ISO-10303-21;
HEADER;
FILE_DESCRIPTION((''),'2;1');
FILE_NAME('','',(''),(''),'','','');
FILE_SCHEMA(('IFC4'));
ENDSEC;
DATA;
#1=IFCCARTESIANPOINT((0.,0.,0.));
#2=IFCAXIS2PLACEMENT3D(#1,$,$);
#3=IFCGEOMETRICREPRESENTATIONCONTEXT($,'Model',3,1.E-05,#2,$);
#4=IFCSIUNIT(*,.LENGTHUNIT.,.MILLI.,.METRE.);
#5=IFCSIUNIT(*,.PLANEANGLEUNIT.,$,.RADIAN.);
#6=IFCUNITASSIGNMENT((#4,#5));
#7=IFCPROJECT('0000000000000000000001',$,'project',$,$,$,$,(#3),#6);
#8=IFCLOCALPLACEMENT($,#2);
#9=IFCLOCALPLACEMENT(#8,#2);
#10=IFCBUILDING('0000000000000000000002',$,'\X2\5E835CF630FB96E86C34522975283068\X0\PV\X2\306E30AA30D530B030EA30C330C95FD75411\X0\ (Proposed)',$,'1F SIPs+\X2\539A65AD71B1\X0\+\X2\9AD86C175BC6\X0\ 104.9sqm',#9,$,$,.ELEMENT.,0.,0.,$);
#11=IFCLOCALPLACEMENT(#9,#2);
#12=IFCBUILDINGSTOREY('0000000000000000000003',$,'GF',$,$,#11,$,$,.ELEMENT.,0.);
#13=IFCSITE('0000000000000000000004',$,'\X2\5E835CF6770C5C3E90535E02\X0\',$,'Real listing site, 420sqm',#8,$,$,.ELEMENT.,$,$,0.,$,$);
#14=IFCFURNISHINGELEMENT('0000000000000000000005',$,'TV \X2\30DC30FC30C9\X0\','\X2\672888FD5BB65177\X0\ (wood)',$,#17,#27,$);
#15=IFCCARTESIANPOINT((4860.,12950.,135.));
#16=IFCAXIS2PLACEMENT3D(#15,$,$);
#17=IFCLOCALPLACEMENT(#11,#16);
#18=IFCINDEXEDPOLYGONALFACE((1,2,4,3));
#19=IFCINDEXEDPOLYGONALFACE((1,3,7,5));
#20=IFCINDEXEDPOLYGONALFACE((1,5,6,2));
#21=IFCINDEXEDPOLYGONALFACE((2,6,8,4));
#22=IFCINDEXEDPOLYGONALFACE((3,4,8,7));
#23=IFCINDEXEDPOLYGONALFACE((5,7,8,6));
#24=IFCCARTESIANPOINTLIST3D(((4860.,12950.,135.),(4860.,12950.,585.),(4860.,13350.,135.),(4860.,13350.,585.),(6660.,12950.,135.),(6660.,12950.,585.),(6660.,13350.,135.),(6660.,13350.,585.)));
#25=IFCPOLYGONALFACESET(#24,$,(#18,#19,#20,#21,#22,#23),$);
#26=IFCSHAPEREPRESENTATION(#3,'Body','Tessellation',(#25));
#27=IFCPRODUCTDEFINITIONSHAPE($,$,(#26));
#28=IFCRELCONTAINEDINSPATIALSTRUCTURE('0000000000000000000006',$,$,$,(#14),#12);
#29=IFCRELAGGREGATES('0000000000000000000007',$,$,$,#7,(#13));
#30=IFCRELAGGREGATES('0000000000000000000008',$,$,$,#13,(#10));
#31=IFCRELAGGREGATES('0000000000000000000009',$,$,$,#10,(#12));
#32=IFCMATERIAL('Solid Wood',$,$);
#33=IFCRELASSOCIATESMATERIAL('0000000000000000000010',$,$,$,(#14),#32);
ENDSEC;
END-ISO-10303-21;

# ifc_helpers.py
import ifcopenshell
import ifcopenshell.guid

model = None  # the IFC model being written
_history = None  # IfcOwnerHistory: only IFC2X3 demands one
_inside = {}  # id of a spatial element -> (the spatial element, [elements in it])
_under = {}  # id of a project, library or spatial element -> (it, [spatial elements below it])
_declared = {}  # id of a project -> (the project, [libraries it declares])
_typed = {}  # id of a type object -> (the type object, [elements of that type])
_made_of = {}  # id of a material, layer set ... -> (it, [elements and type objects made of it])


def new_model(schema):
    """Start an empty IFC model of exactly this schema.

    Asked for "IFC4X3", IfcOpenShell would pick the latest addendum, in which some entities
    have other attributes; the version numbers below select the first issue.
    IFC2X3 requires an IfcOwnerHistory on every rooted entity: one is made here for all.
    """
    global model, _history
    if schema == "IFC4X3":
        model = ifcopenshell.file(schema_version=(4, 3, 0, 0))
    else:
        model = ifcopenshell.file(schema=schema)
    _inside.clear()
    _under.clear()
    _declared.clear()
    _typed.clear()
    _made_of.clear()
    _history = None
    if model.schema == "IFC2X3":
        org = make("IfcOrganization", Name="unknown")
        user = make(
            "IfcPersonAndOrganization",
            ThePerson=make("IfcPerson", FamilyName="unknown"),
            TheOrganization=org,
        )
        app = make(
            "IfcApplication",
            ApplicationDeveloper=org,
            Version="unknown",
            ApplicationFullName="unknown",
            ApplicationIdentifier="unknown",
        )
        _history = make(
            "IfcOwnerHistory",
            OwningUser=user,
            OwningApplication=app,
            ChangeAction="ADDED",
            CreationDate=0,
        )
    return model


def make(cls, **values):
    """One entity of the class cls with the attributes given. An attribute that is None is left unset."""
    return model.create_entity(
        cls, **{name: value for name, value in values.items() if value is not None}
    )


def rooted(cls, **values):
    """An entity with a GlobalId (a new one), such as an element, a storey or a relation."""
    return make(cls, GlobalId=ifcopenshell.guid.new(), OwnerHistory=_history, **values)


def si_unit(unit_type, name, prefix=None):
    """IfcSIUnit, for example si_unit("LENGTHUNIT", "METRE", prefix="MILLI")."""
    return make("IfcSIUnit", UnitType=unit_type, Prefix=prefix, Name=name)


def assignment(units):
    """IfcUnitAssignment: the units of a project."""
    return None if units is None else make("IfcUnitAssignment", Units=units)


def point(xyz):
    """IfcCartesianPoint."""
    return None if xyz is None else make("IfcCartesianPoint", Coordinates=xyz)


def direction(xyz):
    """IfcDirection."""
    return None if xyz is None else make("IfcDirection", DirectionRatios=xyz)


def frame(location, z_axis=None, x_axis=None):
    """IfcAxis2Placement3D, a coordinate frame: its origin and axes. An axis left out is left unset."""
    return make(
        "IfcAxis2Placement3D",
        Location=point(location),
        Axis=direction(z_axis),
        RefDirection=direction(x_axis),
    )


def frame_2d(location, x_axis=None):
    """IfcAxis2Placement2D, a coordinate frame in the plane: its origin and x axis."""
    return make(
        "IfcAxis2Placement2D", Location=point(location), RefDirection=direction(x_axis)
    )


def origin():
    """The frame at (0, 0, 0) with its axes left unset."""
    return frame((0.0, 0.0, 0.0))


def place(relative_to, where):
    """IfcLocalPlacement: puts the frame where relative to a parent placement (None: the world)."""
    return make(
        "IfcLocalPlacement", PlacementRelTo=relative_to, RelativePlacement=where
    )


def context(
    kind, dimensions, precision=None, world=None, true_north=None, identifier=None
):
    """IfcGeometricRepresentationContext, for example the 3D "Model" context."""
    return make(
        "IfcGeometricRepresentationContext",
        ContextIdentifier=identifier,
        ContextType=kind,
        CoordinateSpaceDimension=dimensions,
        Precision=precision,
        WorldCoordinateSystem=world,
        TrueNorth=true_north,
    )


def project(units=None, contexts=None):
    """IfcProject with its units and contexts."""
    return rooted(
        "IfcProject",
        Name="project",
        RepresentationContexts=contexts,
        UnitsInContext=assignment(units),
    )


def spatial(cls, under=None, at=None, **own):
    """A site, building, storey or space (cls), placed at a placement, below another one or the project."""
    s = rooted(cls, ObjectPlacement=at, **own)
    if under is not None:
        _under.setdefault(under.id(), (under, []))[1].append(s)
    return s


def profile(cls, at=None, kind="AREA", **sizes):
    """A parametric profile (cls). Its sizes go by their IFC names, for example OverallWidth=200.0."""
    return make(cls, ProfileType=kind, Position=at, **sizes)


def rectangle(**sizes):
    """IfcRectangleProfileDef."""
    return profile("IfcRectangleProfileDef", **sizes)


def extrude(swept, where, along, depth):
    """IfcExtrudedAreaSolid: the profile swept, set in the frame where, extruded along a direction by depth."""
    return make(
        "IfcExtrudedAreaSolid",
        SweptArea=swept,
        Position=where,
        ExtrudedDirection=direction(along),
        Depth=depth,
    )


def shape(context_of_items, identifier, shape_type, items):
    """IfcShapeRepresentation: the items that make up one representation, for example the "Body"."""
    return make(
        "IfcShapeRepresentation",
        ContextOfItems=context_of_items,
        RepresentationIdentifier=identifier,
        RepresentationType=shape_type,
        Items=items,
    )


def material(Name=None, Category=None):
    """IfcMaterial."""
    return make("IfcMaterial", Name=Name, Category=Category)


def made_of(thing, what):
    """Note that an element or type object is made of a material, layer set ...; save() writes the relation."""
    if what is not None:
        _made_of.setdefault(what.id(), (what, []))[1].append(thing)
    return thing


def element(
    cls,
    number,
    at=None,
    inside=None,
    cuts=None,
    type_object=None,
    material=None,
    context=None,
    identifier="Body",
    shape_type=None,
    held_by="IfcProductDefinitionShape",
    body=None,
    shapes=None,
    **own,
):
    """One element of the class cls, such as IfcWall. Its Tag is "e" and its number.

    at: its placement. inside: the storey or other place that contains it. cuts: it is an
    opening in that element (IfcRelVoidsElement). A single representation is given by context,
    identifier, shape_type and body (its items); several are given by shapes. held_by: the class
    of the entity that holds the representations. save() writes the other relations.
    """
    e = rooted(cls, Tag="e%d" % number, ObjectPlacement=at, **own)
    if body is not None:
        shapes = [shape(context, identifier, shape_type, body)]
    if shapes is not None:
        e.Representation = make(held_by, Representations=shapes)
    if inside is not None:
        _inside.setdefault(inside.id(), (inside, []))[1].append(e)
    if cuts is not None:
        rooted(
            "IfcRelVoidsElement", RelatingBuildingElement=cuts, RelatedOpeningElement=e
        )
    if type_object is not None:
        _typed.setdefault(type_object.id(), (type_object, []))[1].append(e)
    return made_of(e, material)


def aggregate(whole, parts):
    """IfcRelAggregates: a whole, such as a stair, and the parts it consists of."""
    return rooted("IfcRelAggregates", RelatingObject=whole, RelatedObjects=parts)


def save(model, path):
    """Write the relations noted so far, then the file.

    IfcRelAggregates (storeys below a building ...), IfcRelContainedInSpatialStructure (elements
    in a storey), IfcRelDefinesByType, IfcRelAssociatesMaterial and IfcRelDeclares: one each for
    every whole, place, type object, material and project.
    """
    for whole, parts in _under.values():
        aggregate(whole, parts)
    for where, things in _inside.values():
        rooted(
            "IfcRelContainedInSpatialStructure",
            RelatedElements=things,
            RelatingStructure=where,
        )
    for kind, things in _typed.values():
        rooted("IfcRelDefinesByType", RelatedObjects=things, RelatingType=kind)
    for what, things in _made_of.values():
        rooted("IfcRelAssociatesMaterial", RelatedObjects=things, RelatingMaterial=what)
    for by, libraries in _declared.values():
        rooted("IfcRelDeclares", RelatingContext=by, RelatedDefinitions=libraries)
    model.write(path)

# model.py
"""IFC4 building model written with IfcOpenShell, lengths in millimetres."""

from ifc_helpers import new_model, si_unit, frame, frame_2d, origin, place, context, project, spatial, rectangle, extrude, material, element, save


model = new_model("IFC4")

# Units and contexts
model_context = context("Model", 3, precision=1e-05, world=origin())
ifc_project = project(units=[si_unit("LENGTHUNIT", "METRE", prefix="MILLI"), si_unit("PLANEANGLEUNIT", "RADIAN")], contexts=[model_context])

# Site, building, storey
site_placement = place(None, origin())
site = spatial("IfcSite", under=ifc_project, at=site_placement, Name="広島県尾道市", ObjectType="Real listing site, 420sqm", CompositionType="ELEMENT", RefElevation=0.0)
building_placement = place(site_placement, origin())
building = spatial("IfcBuilding", under=site, at=building_placement, Name="広島・雨水利用とPVのオフグリッド志向 (Proposed)", ObjectType="1F SIPs+厚断熱+高気密 104.9sqm", CompositionType="ELEMENT", ElevationOfRefHeight=0.0, ElevationOfTerrain=0.0)
storey_placement = place(building_placement, origin())
storey = spatial("IfcBuildingStorey", under=building, at=storey_placement, Name="GF", CompositionType="ELEMENT", Elevation=0.0)

# Shared definitions
ifc_material_1 = material(Name="Solid Wood")

# Furnishing element
furnishing_placement = place(storey_placement, frame((4860.0, 12950.0, 135.0)))
element("IfcFurnishingElement", 1, at=furnishing_placement, inside=storey, material=ifc_material_1, Name="TV ボード", Description="木製家具 (wood)", context=model_context, shape_type="SweptSolid", body=[
    extrude(rectangle(XDim=1800.0, YDim=400.0, at=frame_2d((900.0, 200.0))), frame((4860.0, 12950.0, 135.0)), (0.0, 0.0, 1.0), 450.0),
])

save(model, "model.ifc")
